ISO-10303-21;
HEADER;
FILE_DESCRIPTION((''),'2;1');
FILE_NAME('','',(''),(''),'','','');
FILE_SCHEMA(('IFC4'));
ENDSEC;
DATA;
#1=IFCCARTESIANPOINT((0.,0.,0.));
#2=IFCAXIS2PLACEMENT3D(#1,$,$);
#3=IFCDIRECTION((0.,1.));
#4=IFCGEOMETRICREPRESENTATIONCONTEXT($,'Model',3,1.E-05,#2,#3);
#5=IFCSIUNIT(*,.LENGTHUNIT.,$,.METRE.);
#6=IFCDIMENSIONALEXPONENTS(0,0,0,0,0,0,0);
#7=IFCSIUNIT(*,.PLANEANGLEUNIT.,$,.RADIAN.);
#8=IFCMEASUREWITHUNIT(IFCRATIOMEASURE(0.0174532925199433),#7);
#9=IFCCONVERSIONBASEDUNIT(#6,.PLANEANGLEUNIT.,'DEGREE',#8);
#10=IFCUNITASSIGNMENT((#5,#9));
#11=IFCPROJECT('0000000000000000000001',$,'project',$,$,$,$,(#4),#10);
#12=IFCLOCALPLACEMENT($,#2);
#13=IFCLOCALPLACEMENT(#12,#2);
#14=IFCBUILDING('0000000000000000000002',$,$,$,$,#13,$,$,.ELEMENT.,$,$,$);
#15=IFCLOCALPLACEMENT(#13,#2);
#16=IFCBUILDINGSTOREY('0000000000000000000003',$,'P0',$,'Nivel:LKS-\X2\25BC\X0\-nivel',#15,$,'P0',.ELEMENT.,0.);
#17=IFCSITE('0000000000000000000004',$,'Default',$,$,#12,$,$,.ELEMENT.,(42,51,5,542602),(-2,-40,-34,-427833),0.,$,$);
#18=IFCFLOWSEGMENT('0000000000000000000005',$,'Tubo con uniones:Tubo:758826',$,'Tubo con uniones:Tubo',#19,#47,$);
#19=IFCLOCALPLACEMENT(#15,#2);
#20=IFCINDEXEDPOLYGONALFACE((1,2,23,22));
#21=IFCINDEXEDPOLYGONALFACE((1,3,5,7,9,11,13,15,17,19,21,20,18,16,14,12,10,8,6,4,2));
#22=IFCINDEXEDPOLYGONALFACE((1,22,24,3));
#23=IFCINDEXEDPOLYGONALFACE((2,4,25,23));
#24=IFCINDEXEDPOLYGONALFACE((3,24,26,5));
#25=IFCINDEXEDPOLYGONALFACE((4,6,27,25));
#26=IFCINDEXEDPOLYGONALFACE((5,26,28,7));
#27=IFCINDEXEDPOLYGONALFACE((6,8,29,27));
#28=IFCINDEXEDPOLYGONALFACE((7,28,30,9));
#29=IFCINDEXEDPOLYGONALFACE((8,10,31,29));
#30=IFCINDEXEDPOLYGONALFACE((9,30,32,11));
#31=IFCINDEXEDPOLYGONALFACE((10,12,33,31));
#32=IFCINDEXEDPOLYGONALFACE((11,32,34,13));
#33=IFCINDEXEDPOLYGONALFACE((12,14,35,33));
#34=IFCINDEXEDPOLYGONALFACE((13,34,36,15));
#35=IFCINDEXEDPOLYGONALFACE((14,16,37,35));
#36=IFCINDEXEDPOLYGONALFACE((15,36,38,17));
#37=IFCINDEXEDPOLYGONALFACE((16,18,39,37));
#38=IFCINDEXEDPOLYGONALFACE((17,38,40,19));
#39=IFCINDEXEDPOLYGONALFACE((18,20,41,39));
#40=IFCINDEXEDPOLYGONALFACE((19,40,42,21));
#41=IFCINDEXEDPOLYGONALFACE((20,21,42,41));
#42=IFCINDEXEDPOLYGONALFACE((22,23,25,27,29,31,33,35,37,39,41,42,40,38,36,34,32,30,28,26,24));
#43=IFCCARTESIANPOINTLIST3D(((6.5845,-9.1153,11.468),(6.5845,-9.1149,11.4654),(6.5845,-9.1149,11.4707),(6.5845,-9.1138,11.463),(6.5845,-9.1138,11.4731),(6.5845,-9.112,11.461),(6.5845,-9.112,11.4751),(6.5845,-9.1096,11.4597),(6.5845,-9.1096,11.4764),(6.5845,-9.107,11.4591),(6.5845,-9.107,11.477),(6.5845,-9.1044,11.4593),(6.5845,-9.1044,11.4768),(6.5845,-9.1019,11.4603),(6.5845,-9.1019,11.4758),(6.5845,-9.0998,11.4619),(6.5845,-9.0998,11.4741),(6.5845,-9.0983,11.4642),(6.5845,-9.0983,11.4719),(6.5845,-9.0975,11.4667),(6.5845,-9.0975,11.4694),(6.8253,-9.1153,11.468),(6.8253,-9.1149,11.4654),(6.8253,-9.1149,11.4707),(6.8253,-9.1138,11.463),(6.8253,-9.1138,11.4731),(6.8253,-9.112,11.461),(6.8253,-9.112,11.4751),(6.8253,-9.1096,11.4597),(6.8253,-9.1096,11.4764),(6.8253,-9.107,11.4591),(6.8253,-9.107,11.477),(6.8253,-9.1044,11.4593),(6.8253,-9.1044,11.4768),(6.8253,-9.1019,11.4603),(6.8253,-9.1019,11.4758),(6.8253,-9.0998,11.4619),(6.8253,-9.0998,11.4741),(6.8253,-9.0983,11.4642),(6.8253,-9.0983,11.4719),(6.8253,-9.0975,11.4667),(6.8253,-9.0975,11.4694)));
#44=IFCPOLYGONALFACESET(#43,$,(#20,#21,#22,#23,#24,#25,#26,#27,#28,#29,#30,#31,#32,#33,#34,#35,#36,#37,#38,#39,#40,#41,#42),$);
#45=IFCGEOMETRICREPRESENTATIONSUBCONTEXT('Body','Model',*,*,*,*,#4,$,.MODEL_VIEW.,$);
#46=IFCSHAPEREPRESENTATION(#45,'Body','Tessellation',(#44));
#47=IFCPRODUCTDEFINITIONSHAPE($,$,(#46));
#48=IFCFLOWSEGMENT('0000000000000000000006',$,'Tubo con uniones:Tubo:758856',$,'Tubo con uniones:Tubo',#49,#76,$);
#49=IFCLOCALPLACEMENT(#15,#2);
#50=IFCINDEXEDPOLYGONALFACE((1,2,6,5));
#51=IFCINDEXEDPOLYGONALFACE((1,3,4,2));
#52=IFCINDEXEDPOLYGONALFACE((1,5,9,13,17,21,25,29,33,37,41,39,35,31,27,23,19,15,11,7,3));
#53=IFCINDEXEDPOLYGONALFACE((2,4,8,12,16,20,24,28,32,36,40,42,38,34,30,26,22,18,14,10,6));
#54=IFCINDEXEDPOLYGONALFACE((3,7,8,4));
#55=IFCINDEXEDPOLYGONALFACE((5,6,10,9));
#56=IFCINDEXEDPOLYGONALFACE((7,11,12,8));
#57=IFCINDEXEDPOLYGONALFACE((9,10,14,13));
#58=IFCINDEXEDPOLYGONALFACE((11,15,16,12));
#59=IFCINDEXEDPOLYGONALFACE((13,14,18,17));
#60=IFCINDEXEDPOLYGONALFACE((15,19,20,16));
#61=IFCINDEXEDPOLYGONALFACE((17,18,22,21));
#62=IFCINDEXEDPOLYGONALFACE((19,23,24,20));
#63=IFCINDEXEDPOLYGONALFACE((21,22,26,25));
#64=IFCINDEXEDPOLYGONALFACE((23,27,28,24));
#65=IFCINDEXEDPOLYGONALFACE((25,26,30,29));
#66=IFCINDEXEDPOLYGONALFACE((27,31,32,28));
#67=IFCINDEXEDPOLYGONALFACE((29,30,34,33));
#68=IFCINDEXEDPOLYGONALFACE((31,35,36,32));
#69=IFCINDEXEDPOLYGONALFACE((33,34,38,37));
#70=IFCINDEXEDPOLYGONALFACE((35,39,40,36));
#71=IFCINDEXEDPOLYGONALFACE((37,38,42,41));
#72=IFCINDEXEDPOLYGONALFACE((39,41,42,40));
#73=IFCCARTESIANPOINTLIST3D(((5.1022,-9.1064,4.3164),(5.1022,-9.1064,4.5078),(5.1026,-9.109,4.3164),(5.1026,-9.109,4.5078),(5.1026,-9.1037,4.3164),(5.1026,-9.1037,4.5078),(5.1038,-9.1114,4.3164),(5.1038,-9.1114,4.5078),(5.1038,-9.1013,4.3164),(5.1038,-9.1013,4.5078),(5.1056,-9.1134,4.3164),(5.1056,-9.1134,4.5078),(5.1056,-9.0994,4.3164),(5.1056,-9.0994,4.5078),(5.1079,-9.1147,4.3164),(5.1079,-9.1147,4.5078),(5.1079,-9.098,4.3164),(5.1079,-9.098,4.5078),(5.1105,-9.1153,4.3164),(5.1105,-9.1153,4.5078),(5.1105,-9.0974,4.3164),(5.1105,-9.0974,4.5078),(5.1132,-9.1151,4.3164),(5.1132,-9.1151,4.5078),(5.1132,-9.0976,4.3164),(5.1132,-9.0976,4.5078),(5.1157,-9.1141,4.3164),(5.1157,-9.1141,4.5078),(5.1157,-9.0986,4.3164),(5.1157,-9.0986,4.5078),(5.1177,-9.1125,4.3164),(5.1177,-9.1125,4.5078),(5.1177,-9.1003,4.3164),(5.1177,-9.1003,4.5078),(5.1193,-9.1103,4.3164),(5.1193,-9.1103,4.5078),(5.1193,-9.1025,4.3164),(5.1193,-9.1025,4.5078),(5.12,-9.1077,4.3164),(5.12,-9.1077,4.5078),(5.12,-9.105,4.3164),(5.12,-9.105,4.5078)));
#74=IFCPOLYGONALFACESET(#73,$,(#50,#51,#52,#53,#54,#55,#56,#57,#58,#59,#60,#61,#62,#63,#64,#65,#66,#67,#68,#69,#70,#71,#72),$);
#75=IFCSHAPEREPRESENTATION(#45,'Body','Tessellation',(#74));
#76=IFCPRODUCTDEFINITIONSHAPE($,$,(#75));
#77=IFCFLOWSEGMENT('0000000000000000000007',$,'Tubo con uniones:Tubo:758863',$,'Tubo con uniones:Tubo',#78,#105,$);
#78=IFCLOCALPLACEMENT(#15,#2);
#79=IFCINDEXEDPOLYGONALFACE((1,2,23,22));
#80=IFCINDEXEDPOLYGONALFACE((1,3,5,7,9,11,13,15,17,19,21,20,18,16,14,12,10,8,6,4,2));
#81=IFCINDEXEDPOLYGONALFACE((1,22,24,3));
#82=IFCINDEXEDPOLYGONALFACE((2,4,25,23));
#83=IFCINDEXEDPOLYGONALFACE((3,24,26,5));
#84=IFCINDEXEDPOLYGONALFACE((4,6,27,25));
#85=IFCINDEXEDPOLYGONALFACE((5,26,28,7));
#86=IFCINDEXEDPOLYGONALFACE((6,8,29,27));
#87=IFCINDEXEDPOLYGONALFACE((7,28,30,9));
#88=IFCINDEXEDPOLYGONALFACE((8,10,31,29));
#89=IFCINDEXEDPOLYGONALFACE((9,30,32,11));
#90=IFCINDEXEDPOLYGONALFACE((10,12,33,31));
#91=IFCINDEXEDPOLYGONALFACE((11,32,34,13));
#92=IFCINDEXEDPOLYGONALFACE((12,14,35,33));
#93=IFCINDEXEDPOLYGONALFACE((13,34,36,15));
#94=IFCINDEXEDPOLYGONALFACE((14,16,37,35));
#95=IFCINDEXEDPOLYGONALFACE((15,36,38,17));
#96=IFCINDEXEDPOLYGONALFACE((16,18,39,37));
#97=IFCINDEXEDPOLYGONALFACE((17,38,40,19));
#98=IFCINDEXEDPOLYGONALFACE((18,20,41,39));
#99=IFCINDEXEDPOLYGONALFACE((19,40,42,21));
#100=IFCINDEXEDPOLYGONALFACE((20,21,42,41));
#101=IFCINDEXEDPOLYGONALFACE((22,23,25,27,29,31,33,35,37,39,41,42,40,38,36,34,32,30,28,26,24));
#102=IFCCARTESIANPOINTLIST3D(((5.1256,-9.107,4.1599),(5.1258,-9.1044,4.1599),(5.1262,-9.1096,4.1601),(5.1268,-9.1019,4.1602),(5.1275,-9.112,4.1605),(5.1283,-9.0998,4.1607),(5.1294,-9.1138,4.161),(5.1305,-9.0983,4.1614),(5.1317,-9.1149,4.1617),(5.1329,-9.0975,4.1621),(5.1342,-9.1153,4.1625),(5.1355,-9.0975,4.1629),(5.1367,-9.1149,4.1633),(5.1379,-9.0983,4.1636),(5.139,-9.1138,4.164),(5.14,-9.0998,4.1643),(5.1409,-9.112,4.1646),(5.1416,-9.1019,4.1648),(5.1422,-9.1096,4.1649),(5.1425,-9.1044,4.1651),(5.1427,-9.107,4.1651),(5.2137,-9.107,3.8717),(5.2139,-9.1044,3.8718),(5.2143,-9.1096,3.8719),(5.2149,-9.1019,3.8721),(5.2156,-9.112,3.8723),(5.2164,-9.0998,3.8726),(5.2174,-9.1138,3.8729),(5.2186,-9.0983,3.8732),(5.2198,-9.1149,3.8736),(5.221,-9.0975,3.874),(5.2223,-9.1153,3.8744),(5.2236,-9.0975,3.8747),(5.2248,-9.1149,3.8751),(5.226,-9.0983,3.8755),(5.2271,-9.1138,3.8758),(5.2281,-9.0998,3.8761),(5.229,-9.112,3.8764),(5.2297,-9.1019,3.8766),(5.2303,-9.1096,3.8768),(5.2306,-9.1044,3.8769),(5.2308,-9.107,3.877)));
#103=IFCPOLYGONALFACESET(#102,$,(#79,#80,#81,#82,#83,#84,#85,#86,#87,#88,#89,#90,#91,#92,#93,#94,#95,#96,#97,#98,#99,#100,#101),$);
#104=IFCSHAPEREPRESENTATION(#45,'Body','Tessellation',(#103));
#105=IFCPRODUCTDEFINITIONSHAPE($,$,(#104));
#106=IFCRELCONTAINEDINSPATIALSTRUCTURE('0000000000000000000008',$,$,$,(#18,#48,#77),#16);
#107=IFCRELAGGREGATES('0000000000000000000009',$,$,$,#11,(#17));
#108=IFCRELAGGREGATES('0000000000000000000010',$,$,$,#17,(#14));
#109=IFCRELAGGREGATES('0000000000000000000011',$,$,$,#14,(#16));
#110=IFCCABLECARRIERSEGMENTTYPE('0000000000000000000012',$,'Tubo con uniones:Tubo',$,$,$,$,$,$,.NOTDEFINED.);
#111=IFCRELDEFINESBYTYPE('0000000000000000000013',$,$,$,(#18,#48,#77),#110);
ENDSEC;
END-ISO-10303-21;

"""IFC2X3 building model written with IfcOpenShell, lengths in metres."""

from ifc_helpers import new_model, entity, si_unit, converted_unit, direction, frame, frame_2d, origin, origin_2d_with_axis, place, context, subcontext, project, spatial, circle, extrude, type_object, element, save


model = new_model("IFC2X3")

# Units and contexts
model_context = context("Model", 3, precision=1e-05, world=origin(), true_north=direction((0.0, 1.0)))
body_context = subcontext(model_context, "Body", "Model", "MODEL_VIEW")
ifc_project = project(units=[si_unit("LENGTHUNIT", "METRE"), converted_unit("PLANEANGLEUNIT", "DEGREE", entity("IfcRatioMeasure", 0.0174532925199433), si_unit("PLANEANGLEUNIT", "RADIAN"), dimensions=[0, 0, 0, 0, 0, 0, 0])], contexts=[model_context])

# Site, building, storey
site_placement = place(None, origin())
site = spatial("IfcSite", under=ifc_project, at=site_placement, Name="Default", CompositionType="ELEMENT", RefLatitude=(42, 51, 5, 542602), RefLongitude=(-2, -40, -34, -427833), RefElevation=0.0)
building_placement = place(site_placement, origin())
building = spatial("IfcBuilding", under=site, at=building_placement, CompositionType="ELEMENT")
storey_placement = place(building_placement, origin())
storey = spatial("IfcBuildingStorey", under=building, at=storey_placement, Name="P0", ObjectType="Nivel:LKS-▼-nivel", LongName="P0", CompositionType="ELEMENT", Elevation=0.0)

# Flow segments
cable_carrier_segment_type = type_object("IfcCableCarrierSegmentType", Name="Tubo con uniones:Tubo", PredefinedType="NOTDEFINED")
flow_segment_1_placement = place(storey_placement, origin())
element("IfcFlowSegment", 1, at=flow_segment_1_placement, inside=storey, type_object=cable_carrier_segment_type, Name="Tubo con uniones:Tubo:758826", ObjectType="Tubo con uniones:Tubo", context=body_context, shape_type="SweptSolid", body=[
    extrude(circle(Radius=0.009, at=origin_2d_with_axis()), frame((6.5845, -9.1064, 11.468), z_axis=(1.0, 0.0, 0.0), x_axis=(0.0, -1.0, 0.0)), (0.0, 0.0, 1.0), 0.2408),
])
flow_segment_2_placement = place(storey_placement, origin())
element("IfcFlowSegment", 2, at=flow_segment_2_placement, inside=storey, type_object=cable_carrier_segment_type, Name="Tubo con uniones:Tubo:758856", ObjectType="Tubo con uniones:Tubo", context=body_context, shape_type="SweptSolid", body=[
    extrude(circle(Radius=0.009, at=origin_2d_with_axis()), frame((5.1112, -9.1064, 4.3164), z_axis=(0.0, 0.0, 1.0), x_axis=(-1.0, 0.0, 0.0)), (0.0, 0.0, 1.0), 0.1913),
])
flow_segment_3_placement = place(storey_placement, origin())
element("IfcFlowSegment", 3, at=flow_segment_3_placement, inside=storey, type_object=cable_carrier_segment_type, Name="Tubo con uniones:Tubo:758863", ObjectType="Tubo con uniones:Tubo", context=body_context, shape_type="SweptSolid", body=[
    extrude(circle(Radius=0.009, at=frame_2d((0.0, 0.0), x_axis=(1.0, 0.0))), frame((5.2223, -9.1064, 3.8744), z_axis=(-0.292372, 0.0, 0.956305), x_axis=(0.0, -1.0, 0.0)), (0.0, 0.0, 1.0), 0.3013),
])

save(model, "model.ifc")
